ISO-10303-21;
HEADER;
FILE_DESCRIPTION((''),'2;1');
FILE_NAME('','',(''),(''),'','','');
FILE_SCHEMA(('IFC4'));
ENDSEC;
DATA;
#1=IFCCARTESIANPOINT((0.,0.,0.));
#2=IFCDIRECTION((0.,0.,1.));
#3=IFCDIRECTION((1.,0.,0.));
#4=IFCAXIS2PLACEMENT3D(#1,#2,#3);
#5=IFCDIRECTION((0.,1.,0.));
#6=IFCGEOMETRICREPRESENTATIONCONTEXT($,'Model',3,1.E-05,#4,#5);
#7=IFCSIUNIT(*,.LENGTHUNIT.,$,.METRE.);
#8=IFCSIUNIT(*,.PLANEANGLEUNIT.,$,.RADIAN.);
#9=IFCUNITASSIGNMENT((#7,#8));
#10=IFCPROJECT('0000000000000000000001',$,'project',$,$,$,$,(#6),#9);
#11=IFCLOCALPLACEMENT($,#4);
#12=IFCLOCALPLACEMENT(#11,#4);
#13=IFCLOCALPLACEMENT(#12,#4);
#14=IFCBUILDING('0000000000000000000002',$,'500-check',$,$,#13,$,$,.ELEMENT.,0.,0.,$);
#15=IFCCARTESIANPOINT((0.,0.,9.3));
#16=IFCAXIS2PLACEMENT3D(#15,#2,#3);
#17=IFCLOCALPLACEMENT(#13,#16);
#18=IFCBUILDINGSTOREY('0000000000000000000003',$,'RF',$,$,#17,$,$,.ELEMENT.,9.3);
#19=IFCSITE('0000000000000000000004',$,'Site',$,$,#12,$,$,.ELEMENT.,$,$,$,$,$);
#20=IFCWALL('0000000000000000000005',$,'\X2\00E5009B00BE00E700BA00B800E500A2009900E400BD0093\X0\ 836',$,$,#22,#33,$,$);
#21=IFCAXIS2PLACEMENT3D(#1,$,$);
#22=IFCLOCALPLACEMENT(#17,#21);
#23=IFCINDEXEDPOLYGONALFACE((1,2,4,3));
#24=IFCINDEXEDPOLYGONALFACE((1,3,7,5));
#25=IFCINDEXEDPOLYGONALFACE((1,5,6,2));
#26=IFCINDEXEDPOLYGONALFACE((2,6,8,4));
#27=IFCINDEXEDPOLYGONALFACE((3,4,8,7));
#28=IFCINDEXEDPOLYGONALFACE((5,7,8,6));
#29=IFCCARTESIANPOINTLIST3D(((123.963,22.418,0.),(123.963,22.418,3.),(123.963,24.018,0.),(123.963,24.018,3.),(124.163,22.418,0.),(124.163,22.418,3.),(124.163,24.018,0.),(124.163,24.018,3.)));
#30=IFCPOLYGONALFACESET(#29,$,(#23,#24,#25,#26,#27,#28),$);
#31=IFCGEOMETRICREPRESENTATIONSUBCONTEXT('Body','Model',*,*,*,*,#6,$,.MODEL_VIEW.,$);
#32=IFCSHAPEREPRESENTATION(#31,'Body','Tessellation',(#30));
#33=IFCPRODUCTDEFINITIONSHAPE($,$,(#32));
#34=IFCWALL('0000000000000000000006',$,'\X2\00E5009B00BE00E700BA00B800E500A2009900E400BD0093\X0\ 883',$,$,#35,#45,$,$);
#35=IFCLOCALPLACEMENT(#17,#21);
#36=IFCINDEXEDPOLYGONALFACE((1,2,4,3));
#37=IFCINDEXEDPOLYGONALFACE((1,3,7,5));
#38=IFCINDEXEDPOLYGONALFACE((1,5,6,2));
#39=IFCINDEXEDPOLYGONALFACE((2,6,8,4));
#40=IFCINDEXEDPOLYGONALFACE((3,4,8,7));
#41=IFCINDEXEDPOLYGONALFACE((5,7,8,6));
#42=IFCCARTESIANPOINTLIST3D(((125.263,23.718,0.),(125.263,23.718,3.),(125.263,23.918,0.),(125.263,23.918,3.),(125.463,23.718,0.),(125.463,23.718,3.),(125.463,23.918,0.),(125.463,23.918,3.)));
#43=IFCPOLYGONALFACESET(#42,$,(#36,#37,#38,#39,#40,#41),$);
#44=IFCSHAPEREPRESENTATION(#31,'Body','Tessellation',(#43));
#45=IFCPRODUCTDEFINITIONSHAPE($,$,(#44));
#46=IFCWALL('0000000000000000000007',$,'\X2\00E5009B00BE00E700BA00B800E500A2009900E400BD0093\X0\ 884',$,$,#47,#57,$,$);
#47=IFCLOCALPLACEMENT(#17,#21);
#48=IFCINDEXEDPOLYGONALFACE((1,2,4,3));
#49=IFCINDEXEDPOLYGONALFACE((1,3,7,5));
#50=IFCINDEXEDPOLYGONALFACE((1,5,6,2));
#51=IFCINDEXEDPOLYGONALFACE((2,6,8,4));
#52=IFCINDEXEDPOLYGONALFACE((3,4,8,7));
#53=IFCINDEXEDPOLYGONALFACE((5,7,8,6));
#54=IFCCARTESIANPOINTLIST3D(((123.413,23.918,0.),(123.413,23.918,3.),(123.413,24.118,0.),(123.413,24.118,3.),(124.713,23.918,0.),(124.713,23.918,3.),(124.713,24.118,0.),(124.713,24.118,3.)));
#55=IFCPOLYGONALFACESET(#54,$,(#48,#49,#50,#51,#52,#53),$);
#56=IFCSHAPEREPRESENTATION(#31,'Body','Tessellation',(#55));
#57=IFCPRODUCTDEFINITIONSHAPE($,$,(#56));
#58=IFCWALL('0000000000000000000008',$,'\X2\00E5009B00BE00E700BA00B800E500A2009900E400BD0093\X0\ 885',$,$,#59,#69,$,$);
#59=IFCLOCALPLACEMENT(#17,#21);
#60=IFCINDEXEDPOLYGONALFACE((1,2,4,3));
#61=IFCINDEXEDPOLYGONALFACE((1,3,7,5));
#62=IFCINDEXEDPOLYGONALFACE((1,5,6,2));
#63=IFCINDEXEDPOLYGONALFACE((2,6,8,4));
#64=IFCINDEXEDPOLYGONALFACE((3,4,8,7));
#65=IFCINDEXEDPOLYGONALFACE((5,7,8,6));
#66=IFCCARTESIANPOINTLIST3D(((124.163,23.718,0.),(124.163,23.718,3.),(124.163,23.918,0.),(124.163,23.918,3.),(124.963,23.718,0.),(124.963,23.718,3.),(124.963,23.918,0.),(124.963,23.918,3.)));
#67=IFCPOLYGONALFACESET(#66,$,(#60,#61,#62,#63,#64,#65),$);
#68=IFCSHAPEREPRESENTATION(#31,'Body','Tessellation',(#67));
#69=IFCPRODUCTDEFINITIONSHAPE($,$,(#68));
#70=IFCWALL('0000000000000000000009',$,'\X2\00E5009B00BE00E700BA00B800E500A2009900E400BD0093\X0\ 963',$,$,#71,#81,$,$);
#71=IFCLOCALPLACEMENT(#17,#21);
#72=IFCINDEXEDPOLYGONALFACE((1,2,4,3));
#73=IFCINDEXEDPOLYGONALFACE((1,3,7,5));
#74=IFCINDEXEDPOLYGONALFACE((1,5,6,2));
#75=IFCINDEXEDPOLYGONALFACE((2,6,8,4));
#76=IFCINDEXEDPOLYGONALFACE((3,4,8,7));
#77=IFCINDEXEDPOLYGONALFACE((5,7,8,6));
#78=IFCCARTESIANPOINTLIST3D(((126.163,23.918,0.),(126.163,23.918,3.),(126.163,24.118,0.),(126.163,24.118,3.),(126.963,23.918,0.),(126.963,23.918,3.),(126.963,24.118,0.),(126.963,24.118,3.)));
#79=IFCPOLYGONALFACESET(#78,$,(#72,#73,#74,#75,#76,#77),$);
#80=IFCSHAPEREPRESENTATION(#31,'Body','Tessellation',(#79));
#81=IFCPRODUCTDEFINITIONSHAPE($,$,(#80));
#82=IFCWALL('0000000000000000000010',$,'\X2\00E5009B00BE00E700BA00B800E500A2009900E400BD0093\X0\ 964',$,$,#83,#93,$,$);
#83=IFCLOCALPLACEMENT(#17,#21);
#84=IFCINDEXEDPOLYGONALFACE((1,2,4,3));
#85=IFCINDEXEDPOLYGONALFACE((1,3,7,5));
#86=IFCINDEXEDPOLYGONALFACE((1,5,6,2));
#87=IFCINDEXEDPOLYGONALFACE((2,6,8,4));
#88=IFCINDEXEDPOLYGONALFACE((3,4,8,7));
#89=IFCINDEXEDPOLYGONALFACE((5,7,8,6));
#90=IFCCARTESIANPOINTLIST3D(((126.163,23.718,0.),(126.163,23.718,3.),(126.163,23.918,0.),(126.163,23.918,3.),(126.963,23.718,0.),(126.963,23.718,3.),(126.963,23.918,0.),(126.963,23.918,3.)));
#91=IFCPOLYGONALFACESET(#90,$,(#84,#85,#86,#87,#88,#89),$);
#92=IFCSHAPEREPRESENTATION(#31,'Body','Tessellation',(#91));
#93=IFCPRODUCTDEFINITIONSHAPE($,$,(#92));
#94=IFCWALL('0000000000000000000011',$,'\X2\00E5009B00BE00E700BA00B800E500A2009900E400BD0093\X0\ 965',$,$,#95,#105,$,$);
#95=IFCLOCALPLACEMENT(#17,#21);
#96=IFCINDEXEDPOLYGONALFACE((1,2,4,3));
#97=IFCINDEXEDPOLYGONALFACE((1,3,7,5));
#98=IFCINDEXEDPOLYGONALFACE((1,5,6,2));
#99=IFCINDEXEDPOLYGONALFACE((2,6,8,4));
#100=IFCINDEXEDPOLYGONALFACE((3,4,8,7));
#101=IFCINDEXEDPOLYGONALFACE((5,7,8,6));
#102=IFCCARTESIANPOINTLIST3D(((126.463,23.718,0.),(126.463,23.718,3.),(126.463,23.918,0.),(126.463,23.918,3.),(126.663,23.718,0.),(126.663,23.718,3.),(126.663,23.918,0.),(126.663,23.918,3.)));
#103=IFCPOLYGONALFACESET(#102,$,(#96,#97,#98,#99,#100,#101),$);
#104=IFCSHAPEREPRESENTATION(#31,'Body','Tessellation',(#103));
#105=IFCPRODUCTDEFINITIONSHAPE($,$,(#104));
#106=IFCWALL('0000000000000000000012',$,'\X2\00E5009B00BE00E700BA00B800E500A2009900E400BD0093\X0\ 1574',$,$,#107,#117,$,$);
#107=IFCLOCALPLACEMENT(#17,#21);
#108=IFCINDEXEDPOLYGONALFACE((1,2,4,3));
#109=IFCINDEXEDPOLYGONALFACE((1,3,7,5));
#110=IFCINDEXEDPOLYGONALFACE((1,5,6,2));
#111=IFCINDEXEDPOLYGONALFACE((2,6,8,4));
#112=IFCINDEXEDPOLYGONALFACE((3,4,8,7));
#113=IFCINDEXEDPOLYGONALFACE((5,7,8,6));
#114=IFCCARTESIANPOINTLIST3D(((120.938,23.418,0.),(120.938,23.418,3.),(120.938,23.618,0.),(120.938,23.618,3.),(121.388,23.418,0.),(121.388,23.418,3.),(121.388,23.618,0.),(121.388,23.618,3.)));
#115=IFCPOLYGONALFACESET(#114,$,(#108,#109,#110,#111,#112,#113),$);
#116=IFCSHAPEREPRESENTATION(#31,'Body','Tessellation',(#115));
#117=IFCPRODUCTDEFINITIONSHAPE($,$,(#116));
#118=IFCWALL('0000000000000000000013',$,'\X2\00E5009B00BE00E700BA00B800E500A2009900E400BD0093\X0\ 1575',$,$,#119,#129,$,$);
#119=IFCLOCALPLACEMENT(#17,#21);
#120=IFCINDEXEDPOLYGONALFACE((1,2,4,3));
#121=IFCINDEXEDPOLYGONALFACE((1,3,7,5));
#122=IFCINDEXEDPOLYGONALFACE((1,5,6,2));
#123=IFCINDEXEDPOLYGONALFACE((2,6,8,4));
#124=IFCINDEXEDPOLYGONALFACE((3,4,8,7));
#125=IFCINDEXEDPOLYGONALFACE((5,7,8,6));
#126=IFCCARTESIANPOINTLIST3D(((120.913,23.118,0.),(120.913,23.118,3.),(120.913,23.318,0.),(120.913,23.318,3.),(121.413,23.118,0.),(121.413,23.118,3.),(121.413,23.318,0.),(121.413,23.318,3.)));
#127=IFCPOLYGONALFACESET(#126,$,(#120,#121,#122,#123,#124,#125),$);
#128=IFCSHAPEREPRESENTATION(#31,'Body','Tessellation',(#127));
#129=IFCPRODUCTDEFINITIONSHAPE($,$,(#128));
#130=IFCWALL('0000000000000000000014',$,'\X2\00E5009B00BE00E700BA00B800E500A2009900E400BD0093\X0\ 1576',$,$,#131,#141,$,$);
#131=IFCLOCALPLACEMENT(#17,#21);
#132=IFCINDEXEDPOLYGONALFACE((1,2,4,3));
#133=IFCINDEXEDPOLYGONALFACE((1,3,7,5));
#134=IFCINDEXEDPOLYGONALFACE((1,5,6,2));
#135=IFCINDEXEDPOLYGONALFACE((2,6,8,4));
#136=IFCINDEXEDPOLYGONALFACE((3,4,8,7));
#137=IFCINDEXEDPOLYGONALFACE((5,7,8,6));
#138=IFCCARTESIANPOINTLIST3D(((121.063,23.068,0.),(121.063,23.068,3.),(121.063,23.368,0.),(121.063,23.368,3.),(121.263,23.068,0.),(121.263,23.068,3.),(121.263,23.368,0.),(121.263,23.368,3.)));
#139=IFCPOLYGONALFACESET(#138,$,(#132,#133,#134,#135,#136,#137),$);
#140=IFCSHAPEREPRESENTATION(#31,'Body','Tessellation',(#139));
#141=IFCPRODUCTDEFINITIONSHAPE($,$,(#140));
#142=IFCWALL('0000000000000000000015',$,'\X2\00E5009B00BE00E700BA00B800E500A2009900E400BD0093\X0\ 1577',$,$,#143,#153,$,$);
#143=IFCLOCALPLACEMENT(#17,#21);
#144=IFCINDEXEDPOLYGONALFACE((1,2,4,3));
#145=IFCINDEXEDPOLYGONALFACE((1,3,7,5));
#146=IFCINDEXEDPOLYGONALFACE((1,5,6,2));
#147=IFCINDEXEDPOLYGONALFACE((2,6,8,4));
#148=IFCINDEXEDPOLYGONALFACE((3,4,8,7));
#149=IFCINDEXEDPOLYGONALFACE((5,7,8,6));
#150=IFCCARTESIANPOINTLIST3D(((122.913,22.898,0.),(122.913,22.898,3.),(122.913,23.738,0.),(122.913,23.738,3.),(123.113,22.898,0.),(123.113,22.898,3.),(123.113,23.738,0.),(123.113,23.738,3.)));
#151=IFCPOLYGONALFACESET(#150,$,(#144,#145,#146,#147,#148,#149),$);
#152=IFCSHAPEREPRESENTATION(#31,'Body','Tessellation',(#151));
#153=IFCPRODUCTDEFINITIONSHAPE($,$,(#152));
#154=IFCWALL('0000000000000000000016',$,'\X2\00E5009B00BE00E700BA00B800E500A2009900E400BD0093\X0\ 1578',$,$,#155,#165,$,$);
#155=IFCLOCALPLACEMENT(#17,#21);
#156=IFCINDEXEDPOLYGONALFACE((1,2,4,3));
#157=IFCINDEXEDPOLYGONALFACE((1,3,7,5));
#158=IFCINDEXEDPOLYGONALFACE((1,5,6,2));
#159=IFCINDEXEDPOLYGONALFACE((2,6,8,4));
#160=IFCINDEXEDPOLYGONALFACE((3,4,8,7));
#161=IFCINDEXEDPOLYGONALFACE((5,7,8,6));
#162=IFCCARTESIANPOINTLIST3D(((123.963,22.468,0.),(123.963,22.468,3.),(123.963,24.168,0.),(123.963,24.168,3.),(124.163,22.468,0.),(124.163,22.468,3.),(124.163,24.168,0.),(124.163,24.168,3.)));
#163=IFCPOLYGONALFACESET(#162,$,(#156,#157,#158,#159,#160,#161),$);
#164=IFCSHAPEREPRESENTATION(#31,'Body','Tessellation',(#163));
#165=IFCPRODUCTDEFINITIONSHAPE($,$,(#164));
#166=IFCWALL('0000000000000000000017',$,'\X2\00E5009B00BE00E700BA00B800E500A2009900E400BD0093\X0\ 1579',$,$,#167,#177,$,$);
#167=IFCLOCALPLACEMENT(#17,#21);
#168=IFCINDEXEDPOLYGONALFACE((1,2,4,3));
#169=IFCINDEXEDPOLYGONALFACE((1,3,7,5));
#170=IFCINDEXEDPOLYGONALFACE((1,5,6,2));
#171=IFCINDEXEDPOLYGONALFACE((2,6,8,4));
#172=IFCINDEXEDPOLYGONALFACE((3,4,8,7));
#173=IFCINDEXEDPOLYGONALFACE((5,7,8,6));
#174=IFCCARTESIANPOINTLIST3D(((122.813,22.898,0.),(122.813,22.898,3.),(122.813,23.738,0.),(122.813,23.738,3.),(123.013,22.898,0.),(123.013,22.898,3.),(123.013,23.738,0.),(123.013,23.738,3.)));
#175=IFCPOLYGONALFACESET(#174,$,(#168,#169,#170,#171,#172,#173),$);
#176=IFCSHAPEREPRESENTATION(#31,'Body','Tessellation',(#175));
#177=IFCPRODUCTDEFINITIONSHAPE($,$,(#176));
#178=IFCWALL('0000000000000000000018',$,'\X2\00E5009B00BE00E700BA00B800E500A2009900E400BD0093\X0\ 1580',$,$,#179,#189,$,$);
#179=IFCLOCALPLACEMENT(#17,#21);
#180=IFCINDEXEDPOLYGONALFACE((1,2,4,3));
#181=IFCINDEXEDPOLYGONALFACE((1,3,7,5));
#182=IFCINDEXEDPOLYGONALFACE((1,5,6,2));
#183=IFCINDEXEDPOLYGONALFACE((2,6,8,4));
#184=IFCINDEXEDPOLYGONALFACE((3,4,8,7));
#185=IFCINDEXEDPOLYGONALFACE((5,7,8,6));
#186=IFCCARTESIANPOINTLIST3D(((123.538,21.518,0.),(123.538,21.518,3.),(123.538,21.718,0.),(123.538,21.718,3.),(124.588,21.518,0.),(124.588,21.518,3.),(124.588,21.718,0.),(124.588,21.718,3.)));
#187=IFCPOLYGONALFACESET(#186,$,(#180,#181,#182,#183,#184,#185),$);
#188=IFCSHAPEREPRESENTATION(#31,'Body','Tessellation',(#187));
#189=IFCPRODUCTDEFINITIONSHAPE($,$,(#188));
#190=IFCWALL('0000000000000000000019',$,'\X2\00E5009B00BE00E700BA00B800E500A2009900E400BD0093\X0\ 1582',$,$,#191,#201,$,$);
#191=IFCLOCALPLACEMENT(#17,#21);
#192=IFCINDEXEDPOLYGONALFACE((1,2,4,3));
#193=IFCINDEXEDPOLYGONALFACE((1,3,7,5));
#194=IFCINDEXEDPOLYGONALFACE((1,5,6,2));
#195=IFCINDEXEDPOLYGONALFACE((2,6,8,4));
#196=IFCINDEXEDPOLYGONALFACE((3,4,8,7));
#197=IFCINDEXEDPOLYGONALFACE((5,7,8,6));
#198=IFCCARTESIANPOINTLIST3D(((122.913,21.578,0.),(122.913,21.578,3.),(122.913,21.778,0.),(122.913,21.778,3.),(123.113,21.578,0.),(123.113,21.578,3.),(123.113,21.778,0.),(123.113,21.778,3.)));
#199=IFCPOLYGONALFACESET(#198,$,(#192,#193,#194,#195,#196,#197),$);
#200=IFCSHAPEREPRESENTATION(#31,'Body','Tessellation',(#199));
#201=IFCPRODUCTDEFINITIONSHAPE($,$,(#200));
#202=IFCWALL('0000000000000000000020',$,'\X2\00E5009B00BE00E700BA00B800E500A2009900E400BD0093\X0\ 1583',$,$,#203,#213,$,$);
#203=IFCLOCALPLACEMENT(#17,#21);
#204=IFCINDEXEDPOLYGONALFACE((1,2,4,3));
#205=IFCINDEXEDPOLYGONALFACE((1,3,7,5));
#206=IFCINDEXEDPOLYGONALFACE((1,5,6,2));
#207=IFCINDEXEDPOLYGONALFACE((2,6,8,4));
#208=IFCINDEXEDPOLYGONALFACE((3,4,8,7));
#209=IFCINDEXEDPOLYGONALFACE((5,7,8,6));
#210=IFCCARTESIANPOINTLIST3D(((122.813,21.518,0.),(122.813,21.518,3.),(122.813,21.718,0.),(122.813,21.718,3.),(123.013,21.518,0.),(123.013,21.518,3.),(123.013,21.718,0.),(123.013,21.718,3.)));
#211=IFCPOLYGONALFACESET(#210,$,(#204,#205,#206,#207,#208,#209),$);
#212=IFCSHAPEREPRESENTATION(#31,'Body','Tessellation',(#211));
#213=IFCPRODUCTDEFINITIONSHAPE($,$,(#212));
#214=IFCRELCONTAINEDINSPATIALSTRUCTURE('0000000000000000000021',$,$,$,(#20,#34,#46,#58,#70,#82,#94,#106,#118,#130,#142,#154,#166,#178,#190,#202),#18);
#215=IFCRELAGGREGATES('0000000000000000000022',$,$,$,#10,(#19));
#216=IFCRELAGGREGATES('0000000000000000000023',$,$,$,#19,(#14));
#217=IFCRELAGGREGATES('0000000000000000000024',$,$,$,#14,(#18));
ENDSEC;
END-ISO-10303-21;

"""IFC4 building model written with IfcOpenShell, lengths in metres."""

from ifc_helpers import new_model, si_unit, direction, frame, frame_2d, origin_with_axes, place, context, subcontext, project, spatial, rectangle, extrude, element, save


model = new_model("IFC4")

# Units and contexts
model_context = context("Model", 3, precision=1e-05, world=origin_with_axes(), true_north=direction((0.0, 1.0, 0.0)))
body_context = subcontext(model_context, "Body", "Model", "MODEL_VIEW")
ifc_project = project(units=[si_unit("LENGTHUNIT", "METRE"), si_unit("PLANEANGLEUNIT", "RADIAN")], contexts=[model_context])

# Site, building, storey
placement = place(None, origin_with_axes())
site_placement = place(placement, origin_with_axes())
site = spatial("IfcSite", under=ifc_project, at=site_placement, Name="Site", CompositionType="ELEMENT")
building_placement = place(site_placement, origin_with_axes())
building = spatial("IfcBuilding", under=site, at=building_placement, Name="500-check", CompositionType="ELEMENT", ElevationOfRefHeight=0.0, ElevationOfTerrain=0.0)
storey_placement = place(building_placement, frame((0.0, 0.0, 9.3), z_axis=(0.0, 0.0, 1.0), x_axis=(1.0, 0.0, 0.0)))
storey = spatial("IfcBuildingStorey", under=building, at=storey_placement, Name="RF", CompositionType="ELEMENT", Elevation=9.3)

# Walls
wall_1_placement = place(storey_placement, frame((124.063, 23.218, 0.0), z_axis=(0.0, 0.0, 1.0), x_axis=(0.0, -1.0, 0.0)))
element("IfcWall", 1, at=wall_1_placement, inside=storey, Name="å\u009b¾çº¸å¢\u0099ä½\u0093 836", context=body_context, shape_type="SweptSolid", body=[
    extrude(rectangle(XDim=1.6, YDim=0.2, at=frame_2d((0.0, 0.0), x_axis=(1.0, 0.0, 0.0))), frame((0.0, 0.0, 0.0), z_axis=(0.0, 0.0, 1.0)), (0.0, 0.0, 1.0), 3.0),
])
wall_2_placement = place(storey_placement, frame((125.363, 23.818, 0.0), z_axis=(0.0, 0.0, 1.0), x_axis=(0.0, 1.0, 0.0)))
element("IfcWall", 2, at=wall_2_placement, inside=storey, Name="å\u009b¾çº¸å¢\u0099ä½\u0093 883", context=body_context, shape_type="SweptSolid", body=[
    extrude(rectangle(XDim=0.2, YDim=0.2, at=frame_2d((0.0, 0.0), x_axis=(1.0, 0.0, 0.0))), frame((0.0, 0.0, 0.0), z_axis=(0.0, 0.0, 1.0)), (0.0, 0.0, 1.0), 3.0),
])
wall_3_placement = place(storey_placement, frame((124.063, 24.018, 0.0), z_axis=(0.0, 0.0, 1.0), x_axis=(1.0, 0.0, 0.0)))
element("IfcWall", 3, at=wall_3_placement, inside=storey, Name="å\u009b¾çº¸å¢\u0099ä½\u0093 884", context=body_context, shape_type="SweptSolid", body=[
    extrude(rectangle(XDim=1.3, YDim=0.2, at=frame_2d((0.0, 0.0), x_axis=(1.0, 0.0, 0.0))), frame((0.0, 0.0, 0.0), z_axis=(0.0, 0.0, 1.0)), (0.0, 0.0, 1.0), 3.0),
])
for number, where, z_axis, x_axis, name in (
    (4, (124.563, 23.818, 0.0), (0.0, 0.0, 1.0), (1.0, 0.0, 0.0), "å\u009b¾çº¸å¢\u0099ä½\u0093 885"),
    (5, (126.563, 24.018, 0.0), (0.0, 0.0, 1.0), (1.0, 0.0, 0.0), "å\u009b¾çº¸å¢\u0099ä½\u0093 963"),
    (6, (126.563, 23.818, 0.0), (0.0, 0.0, 1.0), (1.0, 0.0, 0.0), "å\u009b¾çº¸å¢\u0099ä½\u0093 964"),
):
    element("IfcWall", number, at=place(storey_placement, frame(where, z_axis=z_axis, x_axis=x_axis)), inside=storey, Name=name, context=body_context, shape_type="SweptSolid", body=[
        extrude(rectangle(XDim=0.8, YDim=0.2, at=frame_2d((0.0, 0.0), x_axis=(1.0, 0.0, 0.0))), frame((0.0, 0.0, 0.0), z_axis=(0.0, 0.0, 1.0)), (0.0, 0.0, 1.0), 3.0),
    ])
wall_4_placement = place(storey_placement, frame((126.563, 23.818, 0.0), z_axis=(0.0, 0.0, 1.0), x_axis=(0.0, 1.0, 0.0)))
element("IfcWall", 7, at=wall_4_placement, inside=storey, Name="å\u009b¾çº¸å¢\u0099ä½\u0093 965", context=body_context, shape_type="SweptSolid", body=[
    extrude(rectangle(XDim=0.2, YDim=0.2, at=frame_2d((0.0, 0.0), x_axis=(1.0, 0.0, 0.0))), frame((0.0, 0.0, 0.0), z_axis=(0.0, 0.0, 1.0)), (0.0, 0.0, 1.0), 3.0),
])
wall_5_placement = place(storey_placement, frame((121.163, 23.518, 0.0), z_axis=(0.0, 0.0, 1.0), x_axis=(-1.0, 0.0, 0.0)))
element("IfcWall", 8, at=wall_5_placement, inside=storey, Name="å\u009b¾çº¸å¢\u0099ä½\u0093 1574", context=body_context, shape_type="SweptSolid", body=[
    extrude(rectangle(XDim=0.45, YDim=0.2, at=frame_2d((0.0, 0.0), x_axis=(1.0, 0.0, 0.0))), frame((0.0, 0.0, 0.0), z_axis=(0.0, 0.0, 1.0)), (0.0, 0.0, 1.0), 3.0),
])
wall_6_placement = place(storey_placement, frame((121.163, 23.218, 0.0), z_axis=(0.0, 0.0, 1.0), x_axis=(-1.0, 0.0, 0.0)))
element("IfcWall", 9, at=wall_6_placement, inside=storey, Name="å\u009b¾çº¸å¢\u0099ä½\u0093 1575", context=body_context, shape_type="SweptSolid", body=[
    extrude(rectangle(XDim=0.5, YDim=0.2, at=frame_2d((0.0, 0.0), x_axis=(1.0, 0.0, 0.0))), frame((0.0, 0.0, 0.0), z_axis=(0.0, 0.0, 1.0)), (0.0, 0.0, 1.0), 3.0),
])
wall_7_placement = place(storey_placement, frame((121.163, 23.218, 0.0), z_axis=(0.0, 0.0, 1.0), x_axis=(0.0, 1.0, 0.0)))
element("IfcWall", 10, at=wall_7_placement, inside=storey, Name="å\u009b¾çº¸å¢\u0099ä½\u0093 1576", context=body_context, shape_type="SweptSolid", body=[
    extrude(rectangle(XDim=0.3, YDim=0.2, at=frame_2d((0.0, 0.0), x_axis=(1.0, 0.0, 0.0))), frame((0.0, 0.0, 0.0), z_axis=(0.0, 0.0, 1.0)), (0.0, 0.0, 1.0), 3.0),
])
wall_8_placement = place(storey_placement, frame((123.013, 23.318, 0.0), z_axis=(0.0, 0.0, 1.0), x_axis=(0.0, -1.0, 0.0)))
element("IfcWall", 11, at=wall_8_placement, inside=storey, Name="å\u009b¾çº¸å¢\u0099ä½\u0093 1577", context=body_context, shape_type="SweptSolid", body=[
    extrude(rectangle(XDim=0.84, YDim=0.2, at=frame_2d((0.0, 0.0), x_axis=(1.0, 0.0, 0.0))), frame((0.0, 0.0, 0.0), z_axis=(0.0, 0.0, 1.0)), (0.0, 0.0, 1.0), 3.0),
])
wall_9_placement = place(storey_placement, frame((124.063, 23.318, 0.0), z_axis=(0.0, 0.0, 1.0), x_axis=(0.0, -1.0, 0.0)))
element("IfcWall", 12, at=wall_9_placement, inside=storey, Name="å\u009b¾çº¸å¢\u0099ä½\u0093 1578", context=body_context, shape_type="SweptSolid", body=[
    extrude(rectangle(XDim=1.7, YDim=0.2, at=frame_2d((0.0, 0.0), x_axis=(1.0, 0.0, 0.0))), frame((0.0, 0.0, 0.0), z_axis=(0.0, 0.0, 1.0)), (0.0, 0.0, 1.0), 3.0),
])
wall_10_placement = place(storey_placement, frame((122.913, 23.318, 0.0), z_axis=(0.0, 0.0, 1.0), x_axis=(0.0, -1.0, 0.0)))
element("IfcWall", 13, at=wall_10_placement, inside=storey, Name="å\u009b¾çº¸å¢\u0099ä½\u0093 1579", context=body_context, shape_type="SweptSolid", body=[
    extrude(rectangle(XDim=0.84, YDim=0.2, at=frame_2d((0.0, 0.0), x_axis=(1.0, 0.0, 0.0))), frame((0.0, 0.0, 0.0), z_axis=(0.0, 0.0, 1.0)), (0.0, 0.0, 1.0), 3.0),
])
wall_11_placement = place(storey_placement, frame((124.063, 21.618, 0.0), z_axis=(0.0, 0.0, 1.0), x_axis=(-1.0, 0.0, 0.0)))
element("IfcWall", 14, at=wall_11_placement, inside=storey, Name="å\u009b¾çº¸å¢\u0099ä½\u0093 1580", context=body_context, shape_type="SweptSolid", body=[
    extrude(rectangle(XDim=1.05, YDim=0.2, at=frame_2d((0.0, 0.0), x_axis=(1.0, 0.0, 0.0))), frame((0.0, 0.0, 0.0), z_axis=(0.0, 0.0, 1.0)), (0.0, 0.0, 1.0), 3.0),
])
for number, where, z_axis, x_axis, name in (
    (15, (123.013, 21.678, 0.0), (0.0, 0.0, 1.0), (0.0, -1.0, 0.0), "å\u009b¾çº¸å¢\u0099ä½\u0093 1582"),
    (16, (122.913, 21.618, 0.0), (0.0, 0.0, 1.0), (0.0, -1.0, 0.0), "å\u009b¾çº¸å¢\u0099ä½\u0093 1583"),
):
    element("IfcWall", number, at=place(storey_placement, frame(where, z_axis=z_axis, x_axis=x_axis)), inside=storey, Name=name, context=body_context, shape_type="SweptSolid", body=[
        extrude(rectangle(XDim=0.2, YDim=0.2, at=frame_2d((0.0, 0.0), x_axis=(1.0, 0.0, 0.0))), frame((0.0, 0.0, 0.0), z_axis=(0.0, 0.0, 1.0)), (0.0, 0.0, 1.0), 3.0),
    ])

save(model, "model.ifc")
